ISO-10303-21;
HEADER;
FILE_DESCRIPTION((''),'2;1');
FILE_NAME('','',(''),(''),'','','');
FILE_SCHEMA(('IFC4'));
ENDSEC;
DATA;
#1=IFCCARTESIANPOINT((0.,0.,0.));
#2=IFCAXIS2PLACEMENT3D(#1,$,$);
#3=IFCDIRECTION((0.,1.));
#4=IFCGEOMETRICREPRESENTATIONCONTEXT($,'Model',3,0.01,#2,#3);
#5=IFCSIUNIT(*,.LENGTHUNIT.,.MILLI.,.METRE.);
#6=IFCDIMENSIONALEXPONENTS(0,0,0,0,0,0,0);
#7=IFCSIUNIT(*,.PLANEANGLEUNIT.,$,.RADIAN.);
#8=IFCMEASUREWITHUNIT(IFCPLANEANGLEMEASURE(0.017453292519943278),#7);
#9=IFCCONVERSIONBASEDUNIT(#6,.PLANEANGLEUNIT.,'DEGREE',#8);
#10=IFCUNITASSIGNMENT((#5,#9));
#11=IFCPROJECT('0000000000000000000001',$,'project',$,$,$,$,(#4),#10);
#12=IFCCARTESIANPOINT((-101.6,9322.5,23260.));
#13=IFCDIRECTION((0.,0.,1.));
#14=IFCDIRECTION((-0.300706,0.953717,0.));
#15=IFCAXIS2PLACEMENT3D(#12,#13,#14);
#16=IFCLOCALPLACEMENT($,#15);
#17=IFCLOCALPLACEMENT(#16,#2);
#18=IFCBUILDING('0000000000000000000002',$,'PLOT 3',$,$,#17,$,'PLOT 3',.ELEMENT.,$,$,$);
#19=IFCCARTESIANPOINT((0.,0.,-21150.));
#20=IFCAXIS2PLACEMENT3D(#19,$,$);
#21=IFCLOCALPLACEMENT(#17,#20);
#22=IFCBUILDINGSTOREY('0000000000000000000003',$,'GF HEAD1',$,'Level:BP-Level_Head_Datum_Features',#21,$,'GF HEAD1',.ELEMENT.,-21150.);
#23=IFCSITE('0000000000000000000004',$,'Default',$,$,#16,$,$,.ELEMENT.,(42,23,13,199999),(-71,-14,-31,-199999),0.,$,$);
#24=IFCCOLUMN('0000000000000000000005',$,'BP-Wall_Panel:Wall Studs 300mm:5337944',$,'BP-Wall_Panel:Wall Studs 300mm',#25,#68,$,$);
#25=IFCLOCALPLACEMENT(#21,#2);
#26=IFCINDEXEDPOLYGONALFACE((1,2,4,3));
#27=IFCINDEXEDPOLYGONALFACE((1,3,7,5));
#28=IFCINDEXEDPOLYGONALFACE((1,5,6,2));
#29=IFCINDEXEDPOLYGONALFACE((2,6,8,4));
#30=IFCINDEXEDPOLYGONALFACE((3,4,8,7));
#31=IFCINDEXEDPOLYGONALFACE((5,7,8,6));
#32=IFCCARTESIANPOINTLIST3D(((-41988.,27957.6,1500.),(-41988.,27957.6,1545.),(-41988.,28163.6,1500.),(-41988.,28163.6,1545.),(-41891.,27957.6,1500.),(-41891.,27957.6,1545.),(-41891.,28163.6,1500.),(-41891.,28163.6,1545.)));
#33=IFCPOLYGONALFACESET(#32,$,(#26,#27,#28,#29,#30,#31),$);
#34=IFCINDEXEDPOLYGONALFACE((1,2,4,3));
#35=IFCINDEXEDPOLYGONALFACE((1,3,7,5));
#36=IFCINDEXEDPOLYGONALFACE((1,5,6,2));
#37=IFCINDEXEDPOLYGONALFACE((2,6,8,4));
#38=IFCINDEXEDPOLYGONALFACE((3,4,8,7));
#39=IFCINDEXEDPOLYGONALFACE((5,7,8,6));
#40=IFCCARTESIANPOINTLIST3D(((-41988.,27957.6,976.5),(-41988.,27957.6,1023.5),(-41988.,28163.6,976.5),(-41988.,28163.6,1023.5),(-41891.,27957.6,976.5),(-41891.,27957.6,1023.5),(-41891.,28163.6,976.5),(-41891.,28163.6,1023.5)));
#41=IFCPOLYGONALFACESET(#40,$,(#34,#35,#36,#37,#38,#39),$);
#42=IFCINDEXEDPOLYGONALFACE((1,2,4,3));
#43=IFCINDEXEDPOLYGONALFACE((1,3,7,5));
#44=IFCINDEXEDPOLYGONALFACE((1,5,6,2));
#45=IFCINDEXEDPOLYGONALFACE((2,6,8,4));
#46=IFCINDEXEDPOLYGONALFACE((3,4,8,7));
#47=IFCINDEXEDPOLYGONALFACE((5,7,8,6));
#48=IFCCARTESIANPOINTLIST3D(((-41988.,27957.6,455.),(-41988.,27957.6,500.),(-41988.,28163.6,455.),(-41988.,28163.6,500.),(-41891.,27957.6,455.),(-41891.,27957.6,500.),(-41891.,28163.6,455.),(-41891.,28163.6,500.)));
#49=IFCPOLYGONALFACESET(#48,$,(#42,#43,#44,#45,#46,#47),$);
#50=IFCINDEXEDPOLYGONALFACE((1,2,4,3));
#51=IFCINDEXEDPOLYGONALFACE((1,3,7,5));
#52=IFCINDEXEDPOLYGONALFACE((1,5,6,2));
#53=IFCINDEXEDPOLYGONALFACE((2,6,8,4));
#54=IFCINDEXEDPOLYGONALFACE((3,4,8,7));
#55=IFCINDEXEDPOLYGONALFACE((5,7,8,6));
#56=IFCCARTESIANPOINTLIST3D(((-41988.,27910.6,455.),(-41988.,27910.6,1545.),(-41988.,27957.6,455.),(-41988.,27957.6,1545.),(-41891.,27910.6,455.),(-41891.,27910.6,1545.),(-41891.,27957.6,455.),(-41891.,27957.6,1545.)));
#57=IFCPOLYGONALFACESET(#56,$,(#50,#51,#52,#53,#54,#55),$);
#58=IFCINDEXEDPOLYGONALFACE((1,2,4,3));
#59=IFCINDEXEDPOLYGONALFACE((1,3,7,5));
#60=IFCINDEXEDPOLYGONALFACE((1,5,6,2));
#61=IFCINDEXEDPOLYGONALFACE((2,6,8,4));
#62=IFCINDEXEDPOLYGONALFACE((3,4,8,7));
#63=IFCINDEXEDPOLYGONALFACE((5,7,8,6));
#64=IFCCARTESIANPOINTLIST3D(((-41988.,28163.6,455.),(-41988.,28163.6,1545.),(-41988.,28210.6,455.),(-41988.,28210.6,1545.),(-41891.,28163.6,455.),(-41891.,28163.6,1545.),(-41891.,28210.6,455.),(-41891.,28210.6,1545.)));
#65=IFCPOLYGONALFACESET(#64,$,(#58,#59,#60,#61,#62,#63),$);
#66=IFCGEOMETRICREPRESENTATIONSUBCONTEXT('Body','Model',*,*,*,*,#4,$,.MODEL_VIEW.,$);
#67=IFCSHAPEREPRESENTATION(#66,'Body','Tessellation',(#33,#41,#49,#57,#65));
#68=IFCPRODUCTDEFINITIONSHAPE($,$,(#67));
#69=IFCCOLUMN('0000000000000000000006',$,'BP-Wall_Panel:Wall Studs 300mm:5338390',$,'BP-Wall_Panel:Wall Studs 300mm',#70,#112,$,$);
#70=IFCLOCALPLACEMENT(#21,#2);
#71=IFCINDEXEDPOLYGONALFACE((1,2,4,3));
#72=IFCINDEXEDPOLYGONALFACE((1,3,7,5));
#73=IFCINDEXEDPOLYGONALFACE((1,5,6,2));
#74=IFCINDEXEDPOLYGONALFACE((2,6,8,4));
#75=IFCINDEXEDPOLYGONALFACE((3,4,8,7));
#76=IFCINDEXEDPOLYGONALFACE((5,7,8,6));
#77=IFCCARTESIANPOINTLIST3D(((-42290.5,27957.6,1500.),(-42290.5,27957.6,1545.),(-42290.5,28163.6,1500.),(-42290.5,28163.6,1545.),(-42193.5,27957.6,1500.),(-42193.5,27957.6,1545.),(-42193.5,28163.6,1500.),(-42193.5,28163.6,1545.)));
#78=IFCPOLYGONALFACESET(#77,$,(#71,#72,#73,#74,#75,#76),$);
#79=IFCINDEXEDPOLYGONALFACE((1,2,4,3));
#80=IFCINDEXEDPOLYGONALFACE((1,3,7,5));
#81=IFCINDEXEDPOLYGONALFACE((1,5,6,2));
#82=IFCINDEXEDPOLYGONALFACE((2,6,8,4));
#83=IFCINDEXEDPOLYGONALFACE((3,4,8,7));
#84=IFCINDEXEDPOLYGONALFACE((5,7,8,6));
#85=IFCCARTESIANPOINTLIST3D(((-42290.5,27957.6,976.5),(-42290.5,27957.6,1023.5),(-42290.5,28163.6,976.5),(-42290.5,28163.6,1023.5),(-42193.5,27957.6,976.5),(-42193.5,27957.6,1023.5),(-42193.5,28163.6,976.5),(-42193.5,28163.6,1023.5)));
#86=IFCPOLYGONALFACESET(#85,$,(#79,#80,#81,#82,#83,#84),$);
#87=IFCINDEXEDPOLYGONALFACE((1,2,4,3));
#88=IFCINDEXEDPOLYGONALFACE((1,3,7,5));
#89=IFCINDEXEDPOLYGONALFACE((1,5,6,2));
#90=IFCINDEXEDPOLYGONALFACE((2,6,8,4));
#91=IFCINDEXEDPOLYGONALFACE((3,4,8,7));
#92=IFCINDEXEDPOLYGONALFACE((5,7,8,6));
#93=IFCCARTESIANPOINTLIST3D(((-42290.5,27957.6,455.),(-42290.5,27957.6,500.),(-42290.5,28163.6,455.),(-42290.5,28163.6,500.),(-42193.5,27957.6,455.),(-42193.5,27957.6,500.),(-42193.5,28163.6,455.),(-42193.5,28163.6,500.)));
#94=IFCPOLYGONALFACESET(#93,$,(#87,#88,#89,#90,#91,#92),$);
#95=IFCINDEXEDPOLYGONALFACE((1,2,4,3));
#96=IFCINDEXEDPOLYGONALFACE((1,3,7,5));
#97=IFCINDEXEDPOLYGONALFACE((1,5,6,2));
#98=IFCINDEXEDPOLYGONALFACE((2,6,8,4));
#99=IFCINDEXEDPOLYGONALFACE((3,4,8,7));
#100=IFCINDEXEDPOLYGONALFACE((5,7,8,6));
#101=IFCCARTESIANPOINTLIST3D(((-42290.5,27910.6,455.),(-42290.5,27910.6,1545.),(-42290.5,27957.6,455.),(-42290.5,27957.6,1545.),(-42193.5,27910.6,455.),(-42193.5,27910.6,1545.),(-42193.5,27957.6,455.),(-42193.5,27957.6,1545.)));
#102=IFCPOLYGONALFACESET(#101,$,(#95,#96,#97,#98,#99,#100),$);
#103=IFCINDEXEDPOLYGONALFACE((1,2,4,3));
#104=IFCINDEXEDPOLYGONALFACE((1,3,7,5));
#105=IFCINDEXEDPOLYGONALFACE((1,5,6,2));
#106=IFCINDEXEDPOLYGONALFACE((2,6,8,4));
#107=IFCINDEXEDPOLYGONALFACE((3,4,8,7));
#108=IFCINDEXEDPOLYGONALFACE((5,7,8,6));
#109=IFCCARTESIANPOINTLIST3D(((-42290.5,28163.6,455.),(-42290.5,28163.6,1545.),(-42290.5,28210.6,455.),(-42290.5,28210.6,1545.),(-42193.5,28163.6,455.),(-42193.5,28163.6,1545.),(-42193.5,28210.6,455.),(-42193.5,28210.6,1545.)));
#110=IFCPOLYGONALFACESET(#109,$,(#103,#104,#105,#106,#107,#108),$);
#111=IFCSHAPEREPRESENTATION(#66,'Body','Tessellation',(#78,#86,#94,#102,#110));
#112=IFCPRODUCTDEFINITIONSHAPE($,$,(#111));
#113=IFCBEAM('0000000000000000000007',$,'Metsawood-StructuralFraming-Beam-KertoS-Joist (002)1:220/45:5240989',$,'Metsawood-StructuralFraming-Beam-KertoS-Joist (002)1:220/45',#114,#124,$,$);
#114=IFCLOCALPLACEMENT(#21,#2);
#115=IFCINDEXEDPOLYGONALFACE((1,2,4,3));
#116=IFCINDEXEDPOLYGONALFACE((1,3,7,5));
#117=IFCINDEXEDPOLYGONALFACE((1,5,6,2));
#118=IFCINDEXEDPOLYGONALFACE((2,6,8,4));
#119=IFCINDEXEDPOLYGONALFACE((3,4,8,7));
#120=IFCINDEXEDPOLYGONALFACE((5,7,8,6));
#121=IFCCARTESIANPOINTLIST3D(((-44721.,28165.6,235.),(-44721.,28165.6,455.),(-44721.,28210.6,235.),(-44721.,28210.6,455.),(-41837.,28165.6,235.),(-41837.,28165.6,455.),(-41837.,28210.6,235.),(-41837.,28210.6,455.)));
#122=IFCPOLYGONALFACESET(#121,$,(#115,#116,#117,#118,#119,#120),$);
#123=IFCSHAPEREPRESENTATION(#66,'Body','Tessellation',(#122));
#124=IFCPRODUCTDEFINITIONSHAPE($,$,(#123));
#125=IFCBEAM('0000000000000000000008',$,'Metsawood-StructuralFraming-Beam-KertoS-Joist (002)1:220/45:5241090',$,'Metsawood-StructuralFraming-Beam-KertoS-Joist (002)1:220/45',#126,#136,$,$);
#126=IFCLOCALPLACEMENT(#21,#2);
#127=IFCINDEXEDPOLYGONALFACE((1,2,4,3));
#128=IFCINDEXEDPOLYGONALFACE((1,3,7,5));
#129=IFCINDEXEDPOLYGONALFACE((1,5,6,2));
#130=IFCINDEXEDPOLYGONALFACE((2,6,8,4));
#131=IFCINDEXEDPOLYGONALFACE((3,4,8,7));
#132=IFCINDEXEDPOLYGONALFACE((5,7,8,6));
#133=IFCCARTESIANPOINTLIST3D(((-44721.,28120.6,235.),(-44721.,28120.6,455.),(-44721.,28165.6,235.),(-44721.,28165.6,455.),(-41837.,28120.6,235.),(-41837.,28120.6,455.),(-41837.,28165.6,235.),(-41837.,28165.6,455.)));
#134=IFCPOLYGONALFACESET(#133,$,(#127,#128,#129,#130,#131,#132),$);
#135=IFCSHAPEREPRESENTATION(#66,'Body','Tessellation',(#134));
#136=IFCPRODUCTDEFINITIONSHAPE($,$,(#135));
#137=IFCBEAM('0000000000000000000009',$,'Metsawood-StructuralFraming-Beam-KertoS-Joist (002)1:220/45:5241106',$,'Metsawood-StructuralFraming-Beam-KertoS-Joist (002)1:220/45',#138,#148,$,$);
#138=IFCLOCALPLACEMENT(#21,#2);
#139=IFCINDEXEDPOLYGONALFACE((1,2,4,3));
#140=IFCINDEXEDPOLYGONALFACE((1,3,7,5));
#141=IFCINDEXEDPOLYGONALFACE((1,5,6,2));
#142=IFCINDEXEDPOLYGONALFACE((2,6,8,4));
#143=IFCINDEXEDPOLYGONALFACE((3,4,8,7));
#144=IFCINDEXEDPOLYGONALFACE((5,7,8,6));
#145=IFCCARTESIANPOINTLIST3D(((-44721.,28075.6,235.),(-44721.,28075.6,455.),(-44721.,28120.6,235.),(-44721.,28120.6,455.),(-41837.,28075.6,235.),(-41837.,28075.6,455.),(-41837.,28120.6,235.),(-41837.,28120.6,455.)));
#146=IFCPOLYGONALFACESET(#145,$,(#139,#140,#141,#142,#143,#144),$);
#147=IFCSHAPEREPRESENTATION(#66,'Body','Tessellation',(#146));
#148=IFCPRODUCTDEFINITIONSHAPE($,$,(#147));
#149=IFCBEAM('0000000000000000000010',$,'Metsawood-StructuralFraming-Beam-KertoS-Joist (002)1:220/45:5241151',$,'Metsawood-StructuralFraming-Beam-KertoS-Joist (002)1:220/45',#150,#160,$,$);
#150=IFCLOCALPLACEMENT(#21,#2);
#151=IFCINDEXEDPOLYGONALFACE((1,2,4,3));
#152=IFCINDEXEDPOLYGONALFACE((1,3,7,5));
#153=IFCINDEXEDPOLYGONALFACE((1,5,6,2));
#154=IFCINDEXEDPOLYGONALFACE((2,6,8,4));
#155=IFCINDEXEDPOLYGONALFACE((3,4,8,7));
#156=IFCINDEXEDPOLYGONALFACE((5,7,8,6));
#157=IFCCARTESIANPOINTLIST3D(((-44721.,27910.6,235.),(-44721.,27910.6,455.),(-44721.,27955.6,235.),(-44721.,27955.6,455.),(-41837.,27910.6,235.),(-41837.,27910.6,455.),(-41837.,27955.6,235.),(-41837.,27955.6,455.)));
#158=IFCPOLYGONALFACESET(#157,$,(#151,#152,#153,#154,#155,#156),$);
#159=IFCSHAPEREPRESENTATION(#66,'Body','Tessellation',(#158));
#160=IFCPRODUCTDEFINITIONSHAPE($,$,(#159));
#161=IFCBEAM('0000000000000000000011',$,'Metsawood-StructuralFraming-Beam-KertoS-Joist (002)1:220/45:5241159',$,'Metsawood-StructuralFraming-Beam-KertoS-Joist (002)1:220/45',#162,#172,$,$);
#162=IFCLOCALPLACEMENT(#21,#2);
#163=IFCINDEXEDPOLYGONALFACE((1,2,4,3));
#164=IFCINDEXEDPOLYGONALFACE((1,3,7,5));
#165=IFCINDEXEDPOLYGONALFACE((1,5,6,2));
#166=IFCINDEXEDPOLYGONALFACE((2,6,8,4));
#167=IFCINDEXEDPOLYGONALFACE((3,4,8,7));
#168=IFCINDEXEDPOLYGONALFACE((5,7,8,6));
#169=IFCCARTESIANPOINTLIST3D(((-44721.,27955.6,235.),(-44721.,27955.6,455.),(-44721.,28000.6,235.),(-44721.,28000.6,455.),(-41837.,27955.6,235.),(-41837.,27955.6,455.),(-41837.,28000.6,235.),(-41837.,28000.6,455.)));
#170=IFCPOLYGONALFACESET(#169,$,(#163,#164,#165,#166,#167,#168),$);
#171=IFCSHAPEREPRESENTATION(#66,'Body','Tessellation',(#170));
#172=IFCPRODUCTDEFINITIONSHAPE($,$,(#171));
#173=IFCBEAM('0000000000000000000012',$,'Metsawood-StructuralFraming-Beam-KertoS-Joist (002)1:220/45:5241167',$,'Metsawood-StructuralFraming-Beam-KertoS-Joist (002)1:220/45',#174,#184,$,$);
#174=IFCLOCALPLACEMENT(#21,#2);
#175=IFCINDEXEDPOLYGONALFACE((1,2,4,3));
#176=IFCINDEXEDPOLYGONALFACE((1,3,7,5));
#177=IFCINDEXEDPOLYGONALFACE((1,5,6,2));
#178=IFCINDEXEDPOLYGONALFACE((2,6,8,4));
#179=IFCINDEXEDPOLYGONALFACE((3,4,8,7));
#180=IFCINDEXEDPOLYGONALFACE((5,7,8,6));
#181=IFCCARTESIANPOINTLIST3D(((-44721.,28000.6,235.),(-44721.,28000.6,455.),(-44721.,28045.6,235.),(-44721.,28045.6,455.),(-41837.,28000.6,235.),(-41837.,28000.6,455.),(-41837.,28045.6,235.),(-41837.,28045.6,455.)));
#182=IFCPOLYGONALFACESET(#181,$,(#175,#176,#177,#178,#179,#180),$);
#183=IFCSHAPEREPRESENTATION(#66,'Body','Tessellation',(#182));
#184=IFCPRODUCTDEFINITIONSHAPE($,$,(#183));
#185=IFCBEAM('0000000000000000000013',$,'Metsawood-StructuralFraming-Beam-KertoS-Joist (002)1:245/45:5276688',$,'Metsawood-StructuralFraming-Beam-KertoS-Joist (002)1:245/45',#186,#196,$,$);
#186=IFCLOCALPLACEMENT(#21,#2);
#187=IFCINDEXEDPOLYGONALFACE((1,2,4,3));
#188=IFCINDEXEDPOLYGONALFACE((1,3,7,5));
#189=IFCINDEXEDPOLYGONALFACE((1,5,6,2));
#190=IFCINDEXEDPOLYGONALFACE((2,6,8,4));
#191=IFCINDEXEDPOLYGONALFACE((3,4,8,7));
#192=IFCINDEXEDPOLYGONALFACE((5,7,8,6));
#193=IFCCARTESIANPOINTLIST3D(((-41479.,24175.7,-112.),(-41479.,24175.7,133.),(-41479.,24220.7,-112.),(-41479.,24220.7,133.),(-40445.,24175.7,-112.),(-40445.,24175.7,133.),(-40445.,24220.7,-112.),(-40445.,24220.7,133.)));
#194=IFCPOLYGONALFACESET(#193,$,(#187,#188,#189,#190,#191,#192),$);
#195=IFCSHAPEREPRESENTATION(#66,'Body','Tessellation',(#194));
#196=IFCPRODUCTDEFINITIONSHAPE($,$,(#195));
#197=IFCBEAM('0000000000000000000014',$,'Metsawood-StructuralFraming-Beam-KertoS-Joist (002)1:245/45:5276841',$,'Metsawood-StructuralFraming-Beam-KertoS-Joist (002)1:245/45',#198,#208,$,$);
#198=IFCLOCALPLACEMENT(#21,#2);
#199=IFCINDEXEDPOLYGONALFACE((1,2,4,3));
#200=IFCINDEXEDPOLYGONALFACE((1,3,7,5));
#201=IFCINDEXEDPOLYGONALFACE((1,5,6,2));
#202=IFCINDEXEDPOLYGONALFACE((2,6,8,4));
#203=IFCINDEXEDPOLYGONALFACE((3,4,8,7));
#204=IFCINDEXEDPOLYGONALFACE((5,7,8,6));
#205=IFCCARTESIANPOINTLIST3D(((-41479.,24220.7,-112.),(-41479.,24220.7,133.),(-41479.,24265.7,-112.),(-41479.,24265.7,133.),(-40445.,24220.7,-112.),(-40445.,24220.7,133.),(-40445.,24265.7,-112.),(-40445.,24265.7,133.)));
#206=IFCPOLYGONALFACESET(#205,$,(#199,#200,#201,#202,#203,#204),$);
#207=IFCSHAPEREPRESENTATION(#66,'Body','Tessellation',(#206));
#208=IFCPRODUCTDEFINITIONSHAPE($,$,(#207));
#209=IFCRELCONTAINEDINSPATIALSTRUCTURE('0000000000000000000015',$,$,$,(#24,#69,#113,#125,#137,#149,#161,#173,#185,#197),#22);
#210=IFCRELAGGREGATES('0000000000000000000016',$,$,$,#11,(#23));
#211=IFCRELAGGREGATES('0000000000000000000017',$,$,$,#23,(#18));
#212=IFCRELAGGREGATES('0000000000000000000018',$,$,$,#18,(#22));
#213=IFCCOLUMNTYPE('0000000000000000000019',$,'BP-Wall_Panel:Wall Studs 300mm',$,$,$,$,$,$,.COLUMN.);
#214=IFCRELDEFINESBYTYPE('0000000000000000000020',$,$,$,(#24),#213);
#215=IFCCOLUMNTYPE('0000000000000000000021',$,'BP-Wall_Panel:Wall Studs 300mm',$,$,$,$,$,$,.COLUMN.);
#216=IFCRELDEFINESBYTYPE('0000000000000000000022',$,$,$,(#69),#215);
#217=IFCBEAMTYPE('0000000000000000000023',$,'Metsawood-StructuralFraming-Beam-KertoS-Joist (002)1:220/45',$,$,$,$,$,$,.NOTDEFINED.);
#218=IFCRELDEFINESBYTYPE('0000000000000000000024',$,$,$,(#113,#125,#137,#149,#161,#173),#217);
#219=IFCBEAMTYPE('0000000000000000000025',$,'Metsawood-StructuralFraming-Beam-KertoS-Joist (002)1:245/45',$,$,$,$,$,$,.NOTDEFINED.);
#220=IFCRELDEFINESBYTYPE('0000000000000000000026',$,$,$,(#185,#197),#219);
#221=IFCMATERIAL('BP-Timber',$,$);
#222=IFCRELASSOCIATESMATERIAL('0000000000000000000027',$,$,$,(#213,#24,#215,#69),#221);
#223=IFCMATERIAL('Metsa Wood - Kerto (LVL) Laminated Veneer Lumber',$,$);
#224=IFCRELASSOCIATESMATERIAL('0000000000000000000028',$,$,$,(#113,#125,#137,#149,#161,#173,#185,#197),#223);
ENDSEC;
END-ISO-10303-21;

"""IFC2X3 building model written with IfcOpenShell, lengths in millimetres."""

from ifc_helpers import new_model, entity, si_unit, converted_unit, direction, frame, frame_2d, origin, place, context, subcontext, project, spatial, rectangle, extrude, source, transform, mapped, material, type_object, type_shapes, element, save


model = new_model("IFC2X3")

# Units and contexts
model_context = context("Model", 3, precision=0.01, world=origin(), true_north=direction((0.0, 1.0)))
body_context = subcontext(model_context, "Body", "Model", "MODEL_VIEW")
ifc_project = project(units=[si_unit("LENGTHUNIT", "METRE", prefix="MILLI"), converted_unit("PLANEANGLEUNIT", "DEGREE", entity("IfcPlaneAngleMeasure", 0.017453292519943278), si_unit("PLANEANGLEUNIT", "RADIAN"), dimensions=[0, 0, 0, 0, 0, 0, 0])], contexts=[model_context])

# Site, building, storey
site_placement = place(None, frame((-101.6, 9322.5, 23260.0), z_axis=(0.0, 0.0, 1.0), x_axis=(-0.300706, 0.953717, 0.0)))
site = spatial("IfcSite", under=ifc_project, at=site_placement, Name="Default", CompositionType="ELEMENT", RefLatitude=(42, 23, 13, 199999), RefLongitude=(-71, -14, -31, -199999), RefElevation=0.0)
building_placement = place(site_placement, origin())
building = spatial("IfcBuilding", under=site, at=building_placement, Name="PLOT 3", LongName="PLOT 3", CompositionType="ELEMENT")
storey_placement = place(building_placement, frame((0.0, 0.0, -21150.0)))
storey = spatial("IfcBuildingStorey", under=building, at=storey_placement, Name="GF HEAD1", ObjectType="Level:BP-Level_Head_Datum_Features", LongName="GF HEAD1", CompositionType="ELEMENT", Elevation=-21150.0)

# Columns
ifc_material_1 = material(Name="BP-Timber")
column_type_1 = type_object("IfcColumnType", Name="BP-Wall_Panel:Wall Studs 300mm", PredefinedType="COLUMN", material=ifc_material_1)
shared_shape_1 = source(origin(), body_context, "Body", "SweptSolid", [
    extrude(rectangle(XDim=97.0, YDim=206.0, at=frame_2d((0.0, 0.0), x_axis=(1.0, 0.0))), frame((-41939.5, 28060.6, -19650.0)), (0.0, 0.0, 1.0), 45.0),
    extrude(rectangle(XDim=97.0, YDim=206.0, at=frame_2d((0.0, 0.0), x_axis=(1.0, 0.0))), frame((-41939.5, 28060.6, -20173.5)), (0.0, 0.0, 1.0), 47.0),
    extrude(rectangle(XDim=97.0, YDim=206.0, at=frame_2d((0.0, 0.0), x_axis=(1.0, 0.0))), frame((-41939.5, 28060.6, -20695.0)), (0.0, 0.0, 1.0), 45.0),
    extrude(rectangle(XDim=47.0, YDim=97.0, at=frame_2d((0.0, 0.0), x_axis=(1.0, 0.0))), frame((-41939.5, 27934.1, -20695.0), z_axis=(0.0, 0.0, 1.0), x_axis=(0.0, 1.0, 0.0)), (0.0, 0.0, 1.0), 1090.0),
    extrude(rectangle(XDim=47.0, YDim=97.0, at=frame_2d((0.0, 0.0), x_axis=(1.0, 0.0))), frame((-41939.5, 28187.1, -20695.0), z_axis=(0.0, 0.0, 1.0), x_axis=(0.0, 1.0, 0.0)), (0.0, 0.0, 1.0), 1090.0),
])
type_shapes(column_type_1, [shared_shape_1])
column_1_placement = place(storey_placement, frame((0.0, 0.0, 21150.0)))
element("IfcColumn", 1, at=column_1_placement, inside=storey, type_object=column_type_1, material=ifc_material_1, Name="BP-Wall_Panel:Wall Studs 300mm:5337944", ObjectType="BP-Wall_Panel:Wall Studs 300mm", context=body_context, shape_type="MappedRepresentation", body=[
    mapped(shared_shape_1, transform((0.0, 0.0, 0.0), scale=1.0)),
])
column_type_2 = type_object("IfcColumnType", Name="BP-Wall_Panel:Wall Studs 300mm", PredefinedType="COLUMN", material=ifc_material_1)
shared_shape_2 = source(origin(), body_context, "Body", "SweptSolid", [
    extrude(rectangle(XDim=97.0, YDim=206.0, at=frame_2d((0.0, 0.0), x_axis=(1.0, 0.0))), frame((-42242.0, 28060.6, -19650.0)), (0.0, 0.0, 1.0), 45.0),
    extrude(rectangle(XDim=97.0, YDim=206.0, at=frame_2d((0.0, 0.0), x_axis=(1.0, 0.0))), frame((-42242.0, 28060.6, -20173.5)), (0.0, 0.0, 1.0), 47.0),
    extrude(rectangle(XDim=97.0, YDim=206.0, at=frame_2d((0.0, 0.0), x_axis=(1.0, 0.0))), frame((-42242.0, 28060.6, -20695.0)), (0.0, 0.0, 1.0), 45.0),
    extrude(rectangle(XDim=47.0, YDim=97.0, at=frame_2d((0.0, 0.0), x_axis=(1.0, 0.0))), frame((-42242.0, 27934.1, -20695.0), z_axis=(0.0, 0.0, 1.0), x_axis=(0.0, 1.0, 0.0)), (0.0, 0.0, 1.0), 1090.0),
    extrude(rectangle(XDim=47.0, YDim=97.0, at=frame_2d((0.0, 0.0), x_axis=(1.0, 0.0))), frame((-42242.0, 28187.1, -20695.0), z_axis=(0.0, 0.0, 1.0), x_axis=(0.0, 1.0, 0.0)), (0.0, 0.0, 1.0), 1090.0),
])
type_shapes(column_type_2, [shared_shape_2])
column_2_placement = place(storey_placement, frame((0.0, 0.0, 21150.0)))
element("IfcColumn", 2, at=column_2_placement, inside=storey, type_object=column_type_2, material=ifc_material_1, Name="BP-Wall_Panel:Wall Studs 300mm:5338390", ObjectType="BP-Wall_Panel:Wall Studs 300mm", context=body_context, shape_type="MappedRepresentation", body=[
    mapped(shared_shape_2, transform((0.0, 0.0, 0.0), scale=1.0)),
])

# Beams
ifc_material_2 = material(Name="Metsa Wood - Kerto (LVL) Laminated Veneer Lumber")
beam_type_1 = type_object("IfcBeamType", Name="Metsawood-StructuralFraming-Beam-KertoS-Joist (002)1:220/45", PredefinedType="NOTDEFINED")
for number, where, z_axis, x_axis, name in (
    (3, (-41837.0, 28188.1, 345.0), (0.0, 0.0, 1.0), (-1.0, 0.0, 0.0), "Metsawood-StructuralFraming-Beam-KertoS-Joist (002)1:220/45:5240989"),
    (4, (-41837.0, 28143.1, 345.0), (0.0, 0.0, 1.0), (-1.0, 0.0, 0.0), "Metsawood-StructuralFraming-Beam-KertoS-Joist (002)1:220/45:5241090"),
    (5, (-41837.0, 28098.1, 345.0), (0.0, 0.0, 1.0), (-1.0, 0.0, 0.0), "Metsawood-StructuralFraming-Beam-KertoS-Joist (002)1:220/45:5241106"),
    (6, (-41837.0, 27933.1, 345.0), (0.0, 0.0, 1.0), (-1.0, 0.0, 0.0), "Metsawood-StructuralFraming-Beam-KertoS-Joist (002)1:220/45:5241151"),
    (7, (-41837.0, 27978.1, 345.0), (0.0, 0.0, 1.0), (-1.0, 0.0, 0.0), "Metsawood-StructuralFraming-Beam-KertoS-Joist (002)1:220/45:5241159"),
):
    element("IfcBeam", number, at=place(storey_placement, frame(where, z_axis=z_axis, x_axis=x_axis)), inside=storey, type_object=beam_type_1, material=ifc_material_2, Name=name, ObjectType="Metsawood-StructuralFraming-Beam-KertoS-Joist (002)1:220/45", context=body_context, shape_type="SweptSolid", body=[
        extrude(rectangle(XDim=220.0, YDim=45.0, at=frame_2d((0.0, 0.0), x_axis=(1.0, 0.0))), frame((0.0, 0.0, 0.0), z_axis=(1.0, 0.0, 0.0), x_axis=(0.0, 0.0, -1.0)), (0.0, 0.0, 1.0), 2884.0),
    ])
beam_1_placement = place(storey_placement, frame((-41837.0, 28023.1, 345.0), z_axis=(0.0, 0.0, 1.0), x_axis=(-1.0, 0.0, 0.0)))
element("IfcBeam", 8, at=beam_1_placement, inside=storey, type_object=beam_type_1, material=ifc_material_2, Name="Metsawood-StructuralFraming-Beam-KertoS-Joist (002)1:220/45:5241167", ObjectType="Metsawood-StructuralFraming-Beam-KertoS-Joist (002)1:220/45", context=body_context, shape_type="SweptSolid", body=[
    extrude(rectangle(XDim=220.0, YDim=45.0, at=frame_2d((0.0, 0.0), x_axis=(1.0, 0.0))), frame((0.0, 0.0, 0.0), z_axis=(1.0, 0.0, 0.0), x_axis=(0.0, 0.0, -1.0)), (0.0, 0.0, 1.0), 2884.0),
])
beam_type_2 = type_object("IfcBeamType", Name="Metsawood-StructuralFraming-Beam-KertoS-Joist (002)1:245/45", PredefinedType="NOTDEFINED")
beam_2_placement = place(storey_placement, frame((-41479.0, 24198.2, 10.5)))
element("IfcBeam", 9, at=beam_2_placement, inside=storey, type_object=beam_type_2, material=ifc_material_2, Name="Metsawood-StructuralFraming-Beam-KertoS-Joist (002)1:245/45:5276688", ObjectType="Metsawood-StructuralFraming-Beam-KertoS-Joist (002)1:245/45", context=body_context, shape_type="SweptSolid", body=[
    extrude(rectangle(XDim=245.0, YDim=45.0, at=frame_2d((0.0, 0.0), x_axis=(1.0, 0.0))), frame((0.0, 0.0, 0.0), z_axis=(1.0, 0.0, 0.0), x_axis=(0.0, 0.0, -1.0)), (0.0, 0.0, 1.0), 1034.0),
])
beam_3_placement = place(storey_placement, frame((-41479.0, 24243.2, 10.5)))
element("IfcBeam", 10, at=beam_3_placement, inside=storey, type_object=beam_type_2, material=ifc_material_2, Name="Metsawood-StructuralFraming-Beam-KertoS-Joist (002)1:245/45:5276841", ObjectType="Metsawood-StructuralFraming-Beam-KertoS-Joist (002)1:245/45", context=body_context, shape_type="SweptSolid", body=[
    extrude(rectangle(XDim=245.0, YDim=45.0, at=frame_2d((0.0, 0.0), x_axis=(1.0, 0.0))), frame((0.0, 0.0, 0.0), z_axis=(1.0, 0.0, 0.0), x_axis=(0.0, 0.0, -1.0)), (0.0, 0.0, 1.0), 1034.0),
])

save(model, "model.ifc")
